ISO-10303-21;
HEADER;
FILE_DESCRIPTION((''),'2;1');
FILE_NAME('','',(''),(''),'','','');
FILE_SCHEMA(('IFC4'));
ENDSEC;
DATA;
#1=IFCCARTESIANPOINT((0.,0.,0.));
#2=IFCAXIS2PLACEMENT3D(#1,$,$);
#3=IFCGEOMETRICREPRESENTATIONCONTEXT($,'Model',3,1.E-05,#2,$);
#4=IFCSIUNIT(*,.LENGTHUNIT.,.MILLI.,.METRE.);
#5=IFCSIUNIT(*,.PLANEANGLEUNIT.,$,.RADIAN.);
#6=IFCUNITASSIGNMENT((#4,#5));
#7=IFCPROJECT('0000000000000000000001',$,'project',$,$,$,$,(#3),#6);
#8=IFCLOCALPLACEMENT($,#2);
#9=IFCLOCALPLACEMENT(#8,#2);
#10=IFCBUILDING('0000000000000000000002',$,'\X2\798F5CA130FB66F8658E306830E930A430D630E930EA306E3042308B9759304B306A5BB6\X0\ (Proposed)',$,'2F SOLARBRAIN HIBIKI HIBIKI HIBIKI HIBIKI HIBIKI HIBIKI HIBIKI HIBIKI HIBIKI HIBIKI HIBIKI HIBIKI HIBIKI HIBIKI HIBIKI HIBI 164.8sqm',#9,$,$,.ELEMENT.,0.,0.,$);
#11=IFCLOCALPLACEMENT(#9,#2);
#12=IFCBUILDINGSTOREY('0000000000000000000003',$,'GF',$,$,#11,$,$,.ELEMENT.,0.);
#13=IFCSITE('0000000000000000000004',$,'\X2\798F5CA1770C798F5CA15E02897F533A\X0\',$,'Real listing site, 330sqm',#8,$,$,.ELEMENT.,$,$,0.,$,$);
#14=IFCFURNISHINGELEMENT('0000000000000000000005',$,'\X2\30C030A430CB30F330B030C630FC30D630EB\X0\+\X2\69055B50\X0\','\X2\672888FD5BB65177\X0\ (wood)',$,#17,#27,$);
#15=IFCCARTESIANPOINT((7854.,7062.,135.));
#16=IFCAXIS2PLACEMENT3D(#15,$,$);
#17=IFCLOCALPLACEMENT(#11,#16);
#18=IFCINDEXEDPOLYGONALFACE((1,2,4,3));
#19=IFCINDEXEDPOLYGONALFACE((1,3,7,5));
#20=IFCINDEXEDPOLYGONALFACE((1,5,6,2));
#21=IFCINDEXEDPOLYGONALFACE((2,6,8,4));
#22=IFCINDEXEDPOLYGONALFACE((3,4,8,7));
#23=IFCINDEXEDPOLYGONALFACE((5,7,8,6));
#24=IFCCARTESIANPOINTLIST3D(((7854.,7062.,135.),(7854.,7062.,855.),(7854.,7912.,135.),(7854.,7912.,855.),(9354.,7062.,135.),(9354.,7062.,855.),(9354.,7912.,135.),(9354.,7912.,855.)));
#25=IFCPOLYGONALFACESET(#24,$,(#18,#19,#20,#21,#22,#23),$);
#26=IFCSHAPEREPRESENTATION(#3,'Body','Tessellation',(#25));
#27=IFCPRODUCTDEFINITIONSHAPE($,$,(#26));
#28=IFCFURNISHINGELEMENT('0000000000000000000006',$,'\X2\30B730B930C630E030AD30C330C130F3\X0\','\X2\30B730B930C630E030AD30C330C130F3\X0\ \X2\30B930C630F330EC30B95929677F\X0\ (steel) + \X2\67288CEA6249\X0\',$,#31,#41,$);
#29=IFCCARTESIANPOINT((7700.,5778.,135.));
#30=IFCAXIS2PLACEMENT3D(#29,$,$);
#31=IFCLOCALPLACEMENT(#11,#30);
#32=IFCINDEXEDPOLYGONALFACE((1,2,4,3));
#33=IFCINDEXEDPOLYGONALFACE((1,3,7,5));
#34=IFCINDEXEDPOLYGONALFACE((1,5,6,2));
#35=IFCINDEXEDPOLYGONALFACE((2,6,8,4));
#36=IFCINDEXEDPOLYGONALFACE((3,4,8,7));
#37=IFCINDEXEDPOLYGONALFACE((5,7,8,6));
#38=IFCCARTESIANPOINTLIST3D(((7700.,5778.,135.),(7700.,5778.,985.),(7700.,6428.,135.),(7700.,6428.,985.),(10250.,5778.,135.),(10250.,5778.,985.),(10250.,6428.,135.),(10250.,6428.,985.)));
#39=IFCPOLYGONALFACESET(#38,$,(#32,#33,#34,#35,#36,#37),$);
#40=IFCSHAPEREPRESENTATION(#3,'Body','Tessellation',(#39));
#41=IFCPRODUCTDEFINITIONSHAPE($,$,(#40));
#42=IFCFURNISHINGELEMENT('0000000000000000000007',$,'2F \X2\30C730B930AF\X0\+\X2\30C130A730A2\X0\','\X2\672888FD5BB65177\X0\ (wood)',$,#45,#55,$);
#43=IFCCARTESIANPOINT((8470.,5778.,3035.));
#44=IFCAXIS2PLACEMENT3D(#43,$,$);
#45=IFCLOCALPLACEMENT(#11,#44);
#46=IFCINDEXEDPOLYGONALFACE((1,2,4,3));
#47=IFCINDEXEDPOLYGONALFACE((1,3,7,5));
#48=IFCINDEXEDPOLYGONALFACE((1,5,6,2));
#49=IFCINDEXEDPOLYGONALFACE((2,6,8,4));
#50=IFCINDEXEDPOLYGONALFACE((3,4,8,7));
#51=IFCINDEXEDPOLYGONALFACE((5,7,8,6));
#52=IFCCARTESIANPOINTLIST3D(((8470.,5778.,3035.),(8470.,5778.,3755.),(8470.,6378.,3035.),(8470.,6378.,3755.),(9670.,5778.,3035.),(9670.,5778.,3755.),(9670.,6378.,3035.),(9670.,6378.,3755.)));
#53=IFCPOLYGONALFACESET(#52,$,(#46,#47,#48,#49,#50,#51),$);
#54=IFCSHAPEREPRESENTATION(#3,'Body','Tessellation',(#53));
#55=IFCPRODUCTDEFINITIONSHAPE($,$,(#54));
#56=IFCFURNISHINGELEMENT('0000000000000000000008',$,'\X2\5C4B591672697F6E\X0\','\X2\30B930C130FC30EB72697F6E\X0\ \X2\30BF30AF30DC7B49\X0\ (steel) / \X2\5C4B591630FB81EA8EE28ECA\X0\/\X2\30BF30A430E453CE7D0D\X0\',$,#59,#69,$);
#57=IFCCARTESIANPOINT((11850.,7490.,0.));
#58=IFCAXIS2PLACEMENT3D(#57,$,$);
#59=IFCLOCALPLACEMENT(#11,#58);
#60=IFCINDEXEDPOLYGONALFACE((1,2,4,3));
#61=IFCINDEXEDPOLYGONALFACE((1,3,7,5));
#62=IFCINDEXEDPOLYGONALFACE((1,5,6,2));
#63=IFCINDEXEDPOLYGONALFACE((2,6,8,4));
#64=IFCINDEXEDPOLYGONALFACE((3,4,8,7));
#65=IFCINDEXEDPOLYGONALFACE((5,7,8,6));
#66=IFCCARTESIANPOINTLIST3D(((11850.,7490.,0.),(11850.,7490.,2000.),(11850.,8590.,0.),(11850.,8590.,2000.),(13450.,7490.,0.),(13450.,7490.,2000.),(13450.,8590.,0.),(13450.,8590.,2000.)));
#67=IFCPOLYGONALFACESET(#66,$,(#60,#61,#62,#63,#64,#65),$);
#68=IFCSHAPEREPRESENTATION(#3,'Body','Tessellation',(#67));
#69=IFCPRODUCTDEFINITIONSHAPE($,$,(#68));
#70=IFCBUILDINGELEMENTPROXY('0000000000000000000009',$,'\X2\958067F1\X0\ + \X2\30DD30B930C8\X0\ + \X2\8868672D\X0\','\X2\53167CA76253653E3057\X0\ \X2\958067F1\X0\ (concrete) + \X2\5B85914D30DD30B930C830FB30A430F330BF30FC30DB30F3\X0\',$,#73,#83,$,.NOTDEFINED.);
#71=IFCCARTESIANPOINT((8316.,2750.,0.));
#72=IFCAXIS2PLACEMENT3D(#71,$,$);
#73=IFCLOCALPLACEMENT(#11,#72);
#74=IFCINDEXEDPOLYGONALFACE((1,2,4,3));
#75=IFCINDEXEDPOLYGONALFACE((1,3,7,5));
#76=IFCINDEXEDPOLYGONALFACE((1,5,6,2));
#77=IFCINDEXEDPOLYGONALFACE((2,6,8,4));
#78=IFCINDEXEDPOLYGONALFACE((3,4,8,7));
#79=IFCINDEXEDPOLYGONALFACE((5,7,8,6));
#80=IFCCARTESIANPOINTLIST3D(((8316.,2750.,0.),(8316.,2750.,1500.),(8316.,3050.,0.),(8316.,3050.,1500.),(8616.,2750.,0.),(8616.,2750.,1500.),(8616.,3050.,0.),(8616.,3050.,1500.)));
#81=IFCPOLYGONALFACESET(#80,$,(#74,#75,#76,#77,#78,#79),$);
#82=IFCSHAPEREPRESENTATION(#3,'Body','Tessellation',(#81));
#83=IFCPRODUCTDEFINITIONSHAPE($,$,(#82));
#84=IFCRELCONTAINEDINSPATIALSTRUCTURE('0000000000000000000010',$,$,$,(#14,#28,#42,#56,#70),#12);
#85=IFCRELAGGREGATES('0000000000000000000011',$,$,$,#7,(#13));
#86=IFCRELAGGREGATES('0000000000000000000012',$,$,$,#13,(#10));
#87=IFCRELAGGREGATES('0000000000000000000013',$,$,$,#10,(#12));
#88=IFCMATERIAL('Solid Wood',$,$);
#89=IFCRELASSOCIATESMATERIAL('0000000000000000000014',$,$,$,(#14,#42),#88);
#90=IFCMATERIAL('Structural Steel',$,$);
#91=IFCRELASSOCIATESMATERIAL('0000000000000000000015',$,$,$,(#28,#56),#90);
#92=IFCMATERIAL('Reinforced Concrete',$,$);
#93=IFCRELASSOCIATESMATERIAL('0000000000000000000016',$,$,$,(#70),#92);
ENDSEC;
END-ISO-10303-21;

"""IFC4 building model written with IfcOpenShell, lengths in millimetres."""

from ifc_helpers import new_model, si_unit, frame, frame_2d, origin, place, context, project, spatial, rectangle, extrude, material, element, save


model = new_model("IFC4")

# Units and contexts
model_context = context("Model", 3, precision=1e-05, world=origin())
ifc_project = project(units=[si_unit("LENGTHUNIT", "METRE", prefix="MILLI"), si_unit("PLANEANGLEUNIT", "RADIAN")], contexts=[model_context])

# Site, building, storey
site_placement = place(None, origin())
site = spatial("IfcSite", under=ifc_project, at=site_placement, Name="福岡県福岡市西区", ObjectType="Real listing site, 330sqm", CompositionType="ELEMENT", RefElevation=0.0)
building_placement = place(site_placement, origin())
building = spatial("IfcBuilding", under=site, at=building_placement, Name="福岡・書斎とライブラリのある静かな家 (Proposed)", ObjectType="2F SOLARBRAIN HIBIKI HIBIKI HIBIKI HIBIKI HIBIKI HIBIKI HIBIKI HIBIKI HIBIKI HIBIKI HIBIKI HIBIKI HIBIKI HIBIKI HIBIKI HIBI 164.8sqm", CompositionType="ELEMENT", ElevationOfRefHeight=0.0, ElevationOfTerrain=0.0)
storey_placement = place(building_placement, origin())
storey = spatial("IfcBuildingStorey", under=building, at=storey_placement, Name="GF", CompositionType="ELEMENT", Elevation=0.0)

# Shared definitions
ifc_material_1 = material(Name="Solid Wood")

# Shared definitions
ifc_material_2 = material(Name="Reinforced Concrete")

# Shared definitions
ifc_material_3 = material(Name="Structural Steel")

# Furnishing elements
furnishing_1_placement = place(storey_placement, frame((7854.0, 7062.0, 135.0)))
element("IfcFurnishingElement", 1, at=furnishing_1_placement, inside=storey, material=ifc_material_1, Name="ダイニングテーブル+椅子", Description="木製家具 (wood)", context=model_context, shape_type="SweptSolid", body=[
    extrude(rectangle(XDim=1500.0, YDim=850.0, at=frame_2d((750.0, 425.0))), frame((7854.0, 7062.0, 135.0)), (0.0, 0.0, 1.0), 720.0),
])
furnishing_2_placement = place(storey_placement, frame((7700.0, 5778.0, 135.0)))
element("IfcFurnishingElement", 2, at=furnishing_2_placement, inside=storey, material=ifc_material_3, Name="システムキッチン", Description="システムキッチン ステンレス天板 (steel) + 木質扉", context=model_context, shape_type="SweptSolid", body=[
    extrude(rectangle(XDim=2550.0, YDim=650.0, at=frame_2d((1275.0, 325.0))), frame((7700.0, 5778.0, 135.0)), (0.0, 0.0, 1.0), 850.0),
])
furnishing_3_placement = place(storey_placement, frame((8470.0, 5778.0, 3035.0)))
element("IfcFurnishingElement", 3, at=furnishing_3_placement, inside=storey, material=ifc_material_1, Name="2F デスク+チェア", Description="木製家具 (wood)", context=model_context, shape_type="SweptSolid", body=[
    extrude(rectangle(XDim=1200.0, YDim=600.0, at=frame_2d((600.0, 300.0))), frame((8470.0, 5778.0, 3035.0)), (0.0, 0.0, 1.0), 720.0),
])
furnishing_4_placement = place(storey_placement, frame((11850.0, 7490.0, 0.0)))
element("IfcFurnishingElement", 4, at=furnishing_4_placement, inside=storey, material=ifc_material_3, Name="屋外物置", Description="スチール物置 タクボ等 (steel) / 屋外・自転車/タイヤ収納", context=model_context, shape_type="SweptSolid", body=[
    extrude(rectangle(XDim=1600.0, YDim=1100.0, at=frame_2d((800.0, 550.0))), frame((11850.0, 7490.0, 0.0)), (0.0, 0.0, 1.0), 2000.0),
])

# Building element proxy
proxy_placement = place(storey_placement, frame((8316.0, 2750.0, 0.0)))
element("IfcBuildingElementProxy", 5, at=proxy_placement, inside=storey, material=ifc_material_2, Name="門柱 + ポスト + 表札", Description="化粧打放し 門柱 (concrete) + 宅配ポスト・インターホン", PredefinedType="NOTDEFINED", context=model_context, shape_type="SweptSolid", body=[
    extrude(rectangle(XDim=300.0, YDim=300.0, at=frame_2d((150.0, 150.0))), frame((8316.0, 2750.0, 0.0)), (0.0, 0.0, 1.0), 1500.0),
])

save(model, "model.ifc")
